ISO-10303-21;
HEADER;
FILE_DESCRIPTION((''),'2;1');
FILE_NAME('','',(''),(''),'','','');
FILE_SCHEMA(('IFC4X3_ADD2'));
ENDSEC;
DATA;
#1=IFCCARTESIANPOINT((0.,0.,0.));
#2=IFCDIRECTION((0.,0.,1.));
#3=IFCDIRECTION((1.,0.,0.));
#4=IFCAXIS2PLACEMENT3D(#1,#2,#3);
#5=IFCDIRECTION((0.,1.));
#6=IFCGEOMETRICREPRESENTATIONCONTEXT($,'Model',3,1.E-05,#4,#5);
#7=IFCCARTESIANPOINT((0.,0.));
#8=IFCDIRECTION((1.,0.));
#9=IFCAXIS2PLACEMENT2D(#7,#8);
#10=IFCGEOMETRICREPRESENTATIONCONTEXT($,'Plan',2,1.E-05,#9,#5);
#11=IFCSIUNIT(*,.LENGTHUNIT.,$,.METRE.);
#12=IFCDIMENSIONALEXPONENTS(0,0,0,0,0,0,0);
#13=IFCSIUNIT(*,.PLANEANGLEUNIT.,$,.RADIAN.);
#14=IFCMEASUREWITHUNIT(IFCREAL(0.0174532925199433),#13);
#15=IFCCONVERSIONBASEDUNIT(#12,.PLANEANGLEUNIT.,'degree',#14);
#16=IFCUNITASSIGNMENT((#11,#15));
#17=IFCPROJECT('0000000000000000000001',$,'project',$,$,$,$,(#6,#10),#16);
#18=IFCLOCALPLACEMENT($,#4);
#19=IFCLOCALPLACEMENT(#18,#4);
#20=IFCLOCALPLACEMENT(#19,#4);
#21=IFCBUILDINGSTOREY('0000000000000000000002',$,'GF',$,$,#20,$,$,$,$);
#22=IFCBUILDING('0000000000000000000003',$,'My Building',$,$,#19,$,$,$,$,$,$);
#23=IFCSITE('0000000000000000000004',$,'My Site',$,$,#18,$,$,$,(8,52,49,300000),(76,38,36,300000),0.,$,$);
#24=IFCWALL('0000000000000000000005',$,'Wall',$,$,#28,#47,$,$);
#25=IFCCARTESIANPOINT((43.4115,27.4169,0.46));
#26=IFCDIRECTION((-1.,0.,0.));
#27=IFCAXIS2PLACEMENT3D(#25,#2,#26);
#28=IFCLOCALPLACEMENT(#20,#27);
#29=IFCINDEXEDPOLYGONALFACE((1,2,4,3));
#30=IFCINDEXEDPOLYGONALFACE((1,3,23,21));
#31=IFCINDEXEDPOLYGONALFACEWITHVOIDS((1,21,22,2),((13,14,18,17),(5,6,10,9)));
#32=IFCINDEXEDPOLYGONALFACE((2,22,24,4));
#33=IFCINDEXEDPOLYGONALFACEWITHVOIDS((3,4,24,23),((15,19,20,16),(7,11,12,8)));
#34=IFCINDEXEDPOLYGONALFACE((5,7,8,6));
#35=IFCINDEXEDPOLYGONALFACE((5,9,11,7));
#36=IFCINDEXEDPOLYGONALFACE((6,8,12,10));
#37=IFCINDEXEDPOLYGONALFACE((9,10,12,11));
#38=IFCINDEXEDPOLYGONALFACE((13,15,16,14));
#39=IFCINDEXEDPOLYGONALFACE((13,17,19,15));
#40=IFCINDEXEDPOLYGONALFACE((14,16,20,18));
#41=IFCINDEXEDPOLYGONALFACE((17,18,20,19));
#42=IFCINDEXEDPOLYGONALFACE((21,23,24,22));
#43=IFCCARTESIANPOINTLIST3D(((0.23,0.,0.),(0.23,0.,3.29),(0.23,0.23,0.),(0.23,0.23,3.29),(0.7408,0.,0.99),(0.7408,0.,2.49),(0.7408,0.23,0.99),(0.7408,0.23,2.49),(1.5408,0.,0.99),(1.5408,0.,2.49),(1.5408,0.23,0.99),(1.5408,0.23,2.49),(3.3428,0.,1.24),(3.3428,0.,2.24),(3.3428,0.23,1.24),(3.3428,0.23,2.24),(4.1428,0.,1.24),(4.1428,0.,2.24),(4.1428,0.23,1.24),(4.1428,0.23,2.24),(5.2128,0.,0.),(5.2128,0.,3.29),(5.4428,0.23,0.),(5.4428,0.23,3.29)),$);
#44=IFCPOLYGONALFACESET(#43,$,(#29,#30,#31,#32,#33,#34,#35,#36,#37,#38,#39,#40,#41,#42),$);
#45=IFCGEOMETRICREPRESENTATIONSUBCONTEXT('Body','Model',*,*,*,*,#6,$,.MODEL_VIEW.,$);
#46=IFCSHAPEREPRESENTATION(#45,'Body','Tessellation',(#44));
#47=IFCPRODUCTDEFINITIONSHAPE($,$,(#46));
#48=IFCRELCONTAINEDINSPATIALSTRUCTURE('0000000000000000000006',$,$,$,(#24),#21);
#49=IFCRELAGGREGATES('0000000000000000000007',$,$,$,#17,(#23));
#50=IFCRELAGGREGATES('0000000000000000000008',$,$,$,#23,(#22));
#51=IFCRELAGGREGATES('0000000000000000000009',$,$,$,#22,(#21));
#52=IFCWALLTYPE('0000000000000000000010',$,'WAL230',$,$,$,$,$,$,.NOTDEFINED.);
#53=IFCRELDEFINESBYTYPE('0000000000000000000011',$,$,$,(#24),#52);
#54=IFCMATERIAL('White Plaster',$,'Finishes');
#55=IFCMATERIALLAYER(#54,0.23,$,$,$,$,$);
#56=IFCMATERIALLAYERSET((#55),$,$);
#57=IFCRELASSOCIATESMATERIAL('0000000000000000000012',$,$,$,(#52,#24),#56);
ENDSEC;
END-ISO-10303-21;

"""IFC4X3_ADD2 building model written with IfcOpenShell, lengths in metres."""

from ifc_helpers import new_model, entity, si_unit, converted_unit, direction, frame, origin_with_axes, origin_2d_with_axis, place, context, subcontext, project, spatial, line, indexed_curve, outline, extrude, source, transform, mapped, material, layer, layer_set, layer_usage, type_object, element, save


model = new_model("IFC4X3_ADD2")

# Units and contexts
model_context = context("Model", 3, precision=1e-05, world=origin_with_axes(), true_north=direction((0.0, 1.0)))
plan_context = context("Plan", 2, precision=1e-05, world=origin_2d_with_axis(), true_north=direction((0.0, 1.0)))
body_context = subcontext(model_context, "Body", "Model", "MODEL_VIEW")
ifc_project = project(units=[si_unit("LENGTHUNIT", "METRE"), converted_unit("PLANEANGLEUNIT", "degree", entity("IfcReal", 0.0174532925199433), si_unit("PLANEANGLEUNIT", "RADIAN"), dimensions=[0, 0, 0, 0, 0, 0, 0])], contexts=[model_context, plan_context])

# Site, building, storey
site_placement = place(None, origin_with_axes())
site = spatial("IfcSite", under=ifc_project, at=site_placement, Name="My Site", RefLatitude=(8, 52, 49, 300000), RefLongitude=(76, 38, 36, 300000), RefElevation=0.0)
building_placement = place(site_placement, origin_with_axes())
building = spatial("IfcBuilding", under=site, at=building_placement, Name="My Building")
storey_placement = place(building_placement, origin_with_axes())
storey = spatial("IfcBuildingStorey", under=building, at=storey_placement, Name="GF")

# Shared definitions
ifc_material_1 = material(Name="White Plaster", Category="Finishes")
ifc_layer_1 = layer(ifc_material_1, 0.23)
ifc_layer_set_1 = layer_set([ifc_layer_1])
wall_type_1 = type_object("IfcWallType", Name="WAL230", PredefinedType="NOTDEFINED", material=ifc_layer_set_1)

# Wall, openings
ifc_layer_usage_1 = layer_usage(ifc_layer_set_1, "AXIS2", "POSITIVE", 0.0)
wall_1_placement = place(storey_placement, frame((43.4115, 27.4169, 0.46), z_axis=(0.0, 0.0, 1.0), x_axis=(-1.0, 0.0, 0.0)))
wall_1 = element("IfcWall", 1, at=wall_1_placement, inside=storey, type_object=wall_type_1, material=ifc_layer_usage_1, Name="Wall", context=body_context, shape_type="SweptSolid", body=[
    extrude(outline(indexed_curve([(0.23, 0.0), (0.23, 0.23), (5.4428, 0.23), (5.2128, 0.0)], segments=[line(1, 2, 3, 4, 1)])), origin_with_axes(), (0.0, 0.0, 1.0), 3.29),
])
shared_shape_1 = source(origin_with_axes(), body_context, "Body", "SweptSolid", [
    extrude(outline(indexed_curve([(0.0, 0.0), (0.8, 0.0), (0.8, 1.5), (0.0, 1.5)], segments=[line(1, 2, 3, 4, 1)])), frame((0.0, -0.6, 0.0), z_axis=(0.0, -1.0, 0.0), x_axis=(1.0, 0.0, 0.0)), (0.0, 0.0, -1.0), 1.2),
])
opening_1_placement = place(wall_1_placement, frame((1.5408, 0.23, 0.99), z_axis=(0.0, 0.0, 1.0), x_axis=(-1.0, 0.0, 0.0)))
element("IfcOpeningElement", 2, at=opening_1_placement, cuts=wall_1, PredefinedType="OPENING", context=body_context, shape_type="MappedRepresentation", body=[
    mapped(shared_shape_1, transform((0.0, 0.0, 0.0), x_axis=(1.0, 0.0, 0.0), y_axis=(0.0, 1.0, 0.0), z_axis=(0.0, 0.0, 1.0), scale=1.0)),
])
opening_2_placement = place(wall_1_placement, frame((0.0424, 0.4017, 0.0), z_axis=(0.0, 0.0, 1.0), x_axis=(-1.0, 0.0, 0.0)))
element("IfcOpeningElement", 3, at=opening_2_placement, cuts=wall_1, PredefinedType="OPENING", context=body_context, shape_type="SweptSolid", body=[
    extrude(outline(indexed_curve([(0.0, 0.0), (0.5, 0.0), (0.5, 0.5), (0.0, 0.5)], segments=[line(1, 2, 3, 4, 1)])), frame((0.0, 0.0, 0.0), z_axis=(0.0, -1.0, 0.0), x_axis=(-1.0, 0.0, 0.0)), (0.0, 0.0, 1.0), 0.5),
])
shared_shape_2 = source(origin_with_axes(), body_context, "Body", "SweptSolid", [
    extrude(outline(indexed_curve([(0.0, 1.0), (0.8, 1.0), (0.8, 0.0), (0.0, 0.0), (0.0, 1.0)])), frame((0.0, -0.6, 0.0), z_axis=(0.0, -1.0, 0.0), x_axis=(1.0, 0.0, 0.0)), (0.0, 0.0, -1.0), 1.2),
])
opening_3_placement = place(wall_1_placement, frame((4.1428, 0.23, 1.24), z_axis=(0.0, 0.0, 1.0), x_axis=(-1.0, 0.0, 0.0)))
element("IfcOpeningElement", 4, at=opening_3_placement, cuts=wall_1, PredefinedType="OPENING", context=body_context, shape_type="MappedRepresentation", body=[
    mapped(shared_shape_2, transform((0.0, 0.0, 0.0), x_axis=(1.0, 0.0, 0.0), y_axis=(0.0, 1.0, 0.0), z_axis=(0.0, 0.0, 1.0), scale=1.0)),
])

save(model, "model.ifc")
